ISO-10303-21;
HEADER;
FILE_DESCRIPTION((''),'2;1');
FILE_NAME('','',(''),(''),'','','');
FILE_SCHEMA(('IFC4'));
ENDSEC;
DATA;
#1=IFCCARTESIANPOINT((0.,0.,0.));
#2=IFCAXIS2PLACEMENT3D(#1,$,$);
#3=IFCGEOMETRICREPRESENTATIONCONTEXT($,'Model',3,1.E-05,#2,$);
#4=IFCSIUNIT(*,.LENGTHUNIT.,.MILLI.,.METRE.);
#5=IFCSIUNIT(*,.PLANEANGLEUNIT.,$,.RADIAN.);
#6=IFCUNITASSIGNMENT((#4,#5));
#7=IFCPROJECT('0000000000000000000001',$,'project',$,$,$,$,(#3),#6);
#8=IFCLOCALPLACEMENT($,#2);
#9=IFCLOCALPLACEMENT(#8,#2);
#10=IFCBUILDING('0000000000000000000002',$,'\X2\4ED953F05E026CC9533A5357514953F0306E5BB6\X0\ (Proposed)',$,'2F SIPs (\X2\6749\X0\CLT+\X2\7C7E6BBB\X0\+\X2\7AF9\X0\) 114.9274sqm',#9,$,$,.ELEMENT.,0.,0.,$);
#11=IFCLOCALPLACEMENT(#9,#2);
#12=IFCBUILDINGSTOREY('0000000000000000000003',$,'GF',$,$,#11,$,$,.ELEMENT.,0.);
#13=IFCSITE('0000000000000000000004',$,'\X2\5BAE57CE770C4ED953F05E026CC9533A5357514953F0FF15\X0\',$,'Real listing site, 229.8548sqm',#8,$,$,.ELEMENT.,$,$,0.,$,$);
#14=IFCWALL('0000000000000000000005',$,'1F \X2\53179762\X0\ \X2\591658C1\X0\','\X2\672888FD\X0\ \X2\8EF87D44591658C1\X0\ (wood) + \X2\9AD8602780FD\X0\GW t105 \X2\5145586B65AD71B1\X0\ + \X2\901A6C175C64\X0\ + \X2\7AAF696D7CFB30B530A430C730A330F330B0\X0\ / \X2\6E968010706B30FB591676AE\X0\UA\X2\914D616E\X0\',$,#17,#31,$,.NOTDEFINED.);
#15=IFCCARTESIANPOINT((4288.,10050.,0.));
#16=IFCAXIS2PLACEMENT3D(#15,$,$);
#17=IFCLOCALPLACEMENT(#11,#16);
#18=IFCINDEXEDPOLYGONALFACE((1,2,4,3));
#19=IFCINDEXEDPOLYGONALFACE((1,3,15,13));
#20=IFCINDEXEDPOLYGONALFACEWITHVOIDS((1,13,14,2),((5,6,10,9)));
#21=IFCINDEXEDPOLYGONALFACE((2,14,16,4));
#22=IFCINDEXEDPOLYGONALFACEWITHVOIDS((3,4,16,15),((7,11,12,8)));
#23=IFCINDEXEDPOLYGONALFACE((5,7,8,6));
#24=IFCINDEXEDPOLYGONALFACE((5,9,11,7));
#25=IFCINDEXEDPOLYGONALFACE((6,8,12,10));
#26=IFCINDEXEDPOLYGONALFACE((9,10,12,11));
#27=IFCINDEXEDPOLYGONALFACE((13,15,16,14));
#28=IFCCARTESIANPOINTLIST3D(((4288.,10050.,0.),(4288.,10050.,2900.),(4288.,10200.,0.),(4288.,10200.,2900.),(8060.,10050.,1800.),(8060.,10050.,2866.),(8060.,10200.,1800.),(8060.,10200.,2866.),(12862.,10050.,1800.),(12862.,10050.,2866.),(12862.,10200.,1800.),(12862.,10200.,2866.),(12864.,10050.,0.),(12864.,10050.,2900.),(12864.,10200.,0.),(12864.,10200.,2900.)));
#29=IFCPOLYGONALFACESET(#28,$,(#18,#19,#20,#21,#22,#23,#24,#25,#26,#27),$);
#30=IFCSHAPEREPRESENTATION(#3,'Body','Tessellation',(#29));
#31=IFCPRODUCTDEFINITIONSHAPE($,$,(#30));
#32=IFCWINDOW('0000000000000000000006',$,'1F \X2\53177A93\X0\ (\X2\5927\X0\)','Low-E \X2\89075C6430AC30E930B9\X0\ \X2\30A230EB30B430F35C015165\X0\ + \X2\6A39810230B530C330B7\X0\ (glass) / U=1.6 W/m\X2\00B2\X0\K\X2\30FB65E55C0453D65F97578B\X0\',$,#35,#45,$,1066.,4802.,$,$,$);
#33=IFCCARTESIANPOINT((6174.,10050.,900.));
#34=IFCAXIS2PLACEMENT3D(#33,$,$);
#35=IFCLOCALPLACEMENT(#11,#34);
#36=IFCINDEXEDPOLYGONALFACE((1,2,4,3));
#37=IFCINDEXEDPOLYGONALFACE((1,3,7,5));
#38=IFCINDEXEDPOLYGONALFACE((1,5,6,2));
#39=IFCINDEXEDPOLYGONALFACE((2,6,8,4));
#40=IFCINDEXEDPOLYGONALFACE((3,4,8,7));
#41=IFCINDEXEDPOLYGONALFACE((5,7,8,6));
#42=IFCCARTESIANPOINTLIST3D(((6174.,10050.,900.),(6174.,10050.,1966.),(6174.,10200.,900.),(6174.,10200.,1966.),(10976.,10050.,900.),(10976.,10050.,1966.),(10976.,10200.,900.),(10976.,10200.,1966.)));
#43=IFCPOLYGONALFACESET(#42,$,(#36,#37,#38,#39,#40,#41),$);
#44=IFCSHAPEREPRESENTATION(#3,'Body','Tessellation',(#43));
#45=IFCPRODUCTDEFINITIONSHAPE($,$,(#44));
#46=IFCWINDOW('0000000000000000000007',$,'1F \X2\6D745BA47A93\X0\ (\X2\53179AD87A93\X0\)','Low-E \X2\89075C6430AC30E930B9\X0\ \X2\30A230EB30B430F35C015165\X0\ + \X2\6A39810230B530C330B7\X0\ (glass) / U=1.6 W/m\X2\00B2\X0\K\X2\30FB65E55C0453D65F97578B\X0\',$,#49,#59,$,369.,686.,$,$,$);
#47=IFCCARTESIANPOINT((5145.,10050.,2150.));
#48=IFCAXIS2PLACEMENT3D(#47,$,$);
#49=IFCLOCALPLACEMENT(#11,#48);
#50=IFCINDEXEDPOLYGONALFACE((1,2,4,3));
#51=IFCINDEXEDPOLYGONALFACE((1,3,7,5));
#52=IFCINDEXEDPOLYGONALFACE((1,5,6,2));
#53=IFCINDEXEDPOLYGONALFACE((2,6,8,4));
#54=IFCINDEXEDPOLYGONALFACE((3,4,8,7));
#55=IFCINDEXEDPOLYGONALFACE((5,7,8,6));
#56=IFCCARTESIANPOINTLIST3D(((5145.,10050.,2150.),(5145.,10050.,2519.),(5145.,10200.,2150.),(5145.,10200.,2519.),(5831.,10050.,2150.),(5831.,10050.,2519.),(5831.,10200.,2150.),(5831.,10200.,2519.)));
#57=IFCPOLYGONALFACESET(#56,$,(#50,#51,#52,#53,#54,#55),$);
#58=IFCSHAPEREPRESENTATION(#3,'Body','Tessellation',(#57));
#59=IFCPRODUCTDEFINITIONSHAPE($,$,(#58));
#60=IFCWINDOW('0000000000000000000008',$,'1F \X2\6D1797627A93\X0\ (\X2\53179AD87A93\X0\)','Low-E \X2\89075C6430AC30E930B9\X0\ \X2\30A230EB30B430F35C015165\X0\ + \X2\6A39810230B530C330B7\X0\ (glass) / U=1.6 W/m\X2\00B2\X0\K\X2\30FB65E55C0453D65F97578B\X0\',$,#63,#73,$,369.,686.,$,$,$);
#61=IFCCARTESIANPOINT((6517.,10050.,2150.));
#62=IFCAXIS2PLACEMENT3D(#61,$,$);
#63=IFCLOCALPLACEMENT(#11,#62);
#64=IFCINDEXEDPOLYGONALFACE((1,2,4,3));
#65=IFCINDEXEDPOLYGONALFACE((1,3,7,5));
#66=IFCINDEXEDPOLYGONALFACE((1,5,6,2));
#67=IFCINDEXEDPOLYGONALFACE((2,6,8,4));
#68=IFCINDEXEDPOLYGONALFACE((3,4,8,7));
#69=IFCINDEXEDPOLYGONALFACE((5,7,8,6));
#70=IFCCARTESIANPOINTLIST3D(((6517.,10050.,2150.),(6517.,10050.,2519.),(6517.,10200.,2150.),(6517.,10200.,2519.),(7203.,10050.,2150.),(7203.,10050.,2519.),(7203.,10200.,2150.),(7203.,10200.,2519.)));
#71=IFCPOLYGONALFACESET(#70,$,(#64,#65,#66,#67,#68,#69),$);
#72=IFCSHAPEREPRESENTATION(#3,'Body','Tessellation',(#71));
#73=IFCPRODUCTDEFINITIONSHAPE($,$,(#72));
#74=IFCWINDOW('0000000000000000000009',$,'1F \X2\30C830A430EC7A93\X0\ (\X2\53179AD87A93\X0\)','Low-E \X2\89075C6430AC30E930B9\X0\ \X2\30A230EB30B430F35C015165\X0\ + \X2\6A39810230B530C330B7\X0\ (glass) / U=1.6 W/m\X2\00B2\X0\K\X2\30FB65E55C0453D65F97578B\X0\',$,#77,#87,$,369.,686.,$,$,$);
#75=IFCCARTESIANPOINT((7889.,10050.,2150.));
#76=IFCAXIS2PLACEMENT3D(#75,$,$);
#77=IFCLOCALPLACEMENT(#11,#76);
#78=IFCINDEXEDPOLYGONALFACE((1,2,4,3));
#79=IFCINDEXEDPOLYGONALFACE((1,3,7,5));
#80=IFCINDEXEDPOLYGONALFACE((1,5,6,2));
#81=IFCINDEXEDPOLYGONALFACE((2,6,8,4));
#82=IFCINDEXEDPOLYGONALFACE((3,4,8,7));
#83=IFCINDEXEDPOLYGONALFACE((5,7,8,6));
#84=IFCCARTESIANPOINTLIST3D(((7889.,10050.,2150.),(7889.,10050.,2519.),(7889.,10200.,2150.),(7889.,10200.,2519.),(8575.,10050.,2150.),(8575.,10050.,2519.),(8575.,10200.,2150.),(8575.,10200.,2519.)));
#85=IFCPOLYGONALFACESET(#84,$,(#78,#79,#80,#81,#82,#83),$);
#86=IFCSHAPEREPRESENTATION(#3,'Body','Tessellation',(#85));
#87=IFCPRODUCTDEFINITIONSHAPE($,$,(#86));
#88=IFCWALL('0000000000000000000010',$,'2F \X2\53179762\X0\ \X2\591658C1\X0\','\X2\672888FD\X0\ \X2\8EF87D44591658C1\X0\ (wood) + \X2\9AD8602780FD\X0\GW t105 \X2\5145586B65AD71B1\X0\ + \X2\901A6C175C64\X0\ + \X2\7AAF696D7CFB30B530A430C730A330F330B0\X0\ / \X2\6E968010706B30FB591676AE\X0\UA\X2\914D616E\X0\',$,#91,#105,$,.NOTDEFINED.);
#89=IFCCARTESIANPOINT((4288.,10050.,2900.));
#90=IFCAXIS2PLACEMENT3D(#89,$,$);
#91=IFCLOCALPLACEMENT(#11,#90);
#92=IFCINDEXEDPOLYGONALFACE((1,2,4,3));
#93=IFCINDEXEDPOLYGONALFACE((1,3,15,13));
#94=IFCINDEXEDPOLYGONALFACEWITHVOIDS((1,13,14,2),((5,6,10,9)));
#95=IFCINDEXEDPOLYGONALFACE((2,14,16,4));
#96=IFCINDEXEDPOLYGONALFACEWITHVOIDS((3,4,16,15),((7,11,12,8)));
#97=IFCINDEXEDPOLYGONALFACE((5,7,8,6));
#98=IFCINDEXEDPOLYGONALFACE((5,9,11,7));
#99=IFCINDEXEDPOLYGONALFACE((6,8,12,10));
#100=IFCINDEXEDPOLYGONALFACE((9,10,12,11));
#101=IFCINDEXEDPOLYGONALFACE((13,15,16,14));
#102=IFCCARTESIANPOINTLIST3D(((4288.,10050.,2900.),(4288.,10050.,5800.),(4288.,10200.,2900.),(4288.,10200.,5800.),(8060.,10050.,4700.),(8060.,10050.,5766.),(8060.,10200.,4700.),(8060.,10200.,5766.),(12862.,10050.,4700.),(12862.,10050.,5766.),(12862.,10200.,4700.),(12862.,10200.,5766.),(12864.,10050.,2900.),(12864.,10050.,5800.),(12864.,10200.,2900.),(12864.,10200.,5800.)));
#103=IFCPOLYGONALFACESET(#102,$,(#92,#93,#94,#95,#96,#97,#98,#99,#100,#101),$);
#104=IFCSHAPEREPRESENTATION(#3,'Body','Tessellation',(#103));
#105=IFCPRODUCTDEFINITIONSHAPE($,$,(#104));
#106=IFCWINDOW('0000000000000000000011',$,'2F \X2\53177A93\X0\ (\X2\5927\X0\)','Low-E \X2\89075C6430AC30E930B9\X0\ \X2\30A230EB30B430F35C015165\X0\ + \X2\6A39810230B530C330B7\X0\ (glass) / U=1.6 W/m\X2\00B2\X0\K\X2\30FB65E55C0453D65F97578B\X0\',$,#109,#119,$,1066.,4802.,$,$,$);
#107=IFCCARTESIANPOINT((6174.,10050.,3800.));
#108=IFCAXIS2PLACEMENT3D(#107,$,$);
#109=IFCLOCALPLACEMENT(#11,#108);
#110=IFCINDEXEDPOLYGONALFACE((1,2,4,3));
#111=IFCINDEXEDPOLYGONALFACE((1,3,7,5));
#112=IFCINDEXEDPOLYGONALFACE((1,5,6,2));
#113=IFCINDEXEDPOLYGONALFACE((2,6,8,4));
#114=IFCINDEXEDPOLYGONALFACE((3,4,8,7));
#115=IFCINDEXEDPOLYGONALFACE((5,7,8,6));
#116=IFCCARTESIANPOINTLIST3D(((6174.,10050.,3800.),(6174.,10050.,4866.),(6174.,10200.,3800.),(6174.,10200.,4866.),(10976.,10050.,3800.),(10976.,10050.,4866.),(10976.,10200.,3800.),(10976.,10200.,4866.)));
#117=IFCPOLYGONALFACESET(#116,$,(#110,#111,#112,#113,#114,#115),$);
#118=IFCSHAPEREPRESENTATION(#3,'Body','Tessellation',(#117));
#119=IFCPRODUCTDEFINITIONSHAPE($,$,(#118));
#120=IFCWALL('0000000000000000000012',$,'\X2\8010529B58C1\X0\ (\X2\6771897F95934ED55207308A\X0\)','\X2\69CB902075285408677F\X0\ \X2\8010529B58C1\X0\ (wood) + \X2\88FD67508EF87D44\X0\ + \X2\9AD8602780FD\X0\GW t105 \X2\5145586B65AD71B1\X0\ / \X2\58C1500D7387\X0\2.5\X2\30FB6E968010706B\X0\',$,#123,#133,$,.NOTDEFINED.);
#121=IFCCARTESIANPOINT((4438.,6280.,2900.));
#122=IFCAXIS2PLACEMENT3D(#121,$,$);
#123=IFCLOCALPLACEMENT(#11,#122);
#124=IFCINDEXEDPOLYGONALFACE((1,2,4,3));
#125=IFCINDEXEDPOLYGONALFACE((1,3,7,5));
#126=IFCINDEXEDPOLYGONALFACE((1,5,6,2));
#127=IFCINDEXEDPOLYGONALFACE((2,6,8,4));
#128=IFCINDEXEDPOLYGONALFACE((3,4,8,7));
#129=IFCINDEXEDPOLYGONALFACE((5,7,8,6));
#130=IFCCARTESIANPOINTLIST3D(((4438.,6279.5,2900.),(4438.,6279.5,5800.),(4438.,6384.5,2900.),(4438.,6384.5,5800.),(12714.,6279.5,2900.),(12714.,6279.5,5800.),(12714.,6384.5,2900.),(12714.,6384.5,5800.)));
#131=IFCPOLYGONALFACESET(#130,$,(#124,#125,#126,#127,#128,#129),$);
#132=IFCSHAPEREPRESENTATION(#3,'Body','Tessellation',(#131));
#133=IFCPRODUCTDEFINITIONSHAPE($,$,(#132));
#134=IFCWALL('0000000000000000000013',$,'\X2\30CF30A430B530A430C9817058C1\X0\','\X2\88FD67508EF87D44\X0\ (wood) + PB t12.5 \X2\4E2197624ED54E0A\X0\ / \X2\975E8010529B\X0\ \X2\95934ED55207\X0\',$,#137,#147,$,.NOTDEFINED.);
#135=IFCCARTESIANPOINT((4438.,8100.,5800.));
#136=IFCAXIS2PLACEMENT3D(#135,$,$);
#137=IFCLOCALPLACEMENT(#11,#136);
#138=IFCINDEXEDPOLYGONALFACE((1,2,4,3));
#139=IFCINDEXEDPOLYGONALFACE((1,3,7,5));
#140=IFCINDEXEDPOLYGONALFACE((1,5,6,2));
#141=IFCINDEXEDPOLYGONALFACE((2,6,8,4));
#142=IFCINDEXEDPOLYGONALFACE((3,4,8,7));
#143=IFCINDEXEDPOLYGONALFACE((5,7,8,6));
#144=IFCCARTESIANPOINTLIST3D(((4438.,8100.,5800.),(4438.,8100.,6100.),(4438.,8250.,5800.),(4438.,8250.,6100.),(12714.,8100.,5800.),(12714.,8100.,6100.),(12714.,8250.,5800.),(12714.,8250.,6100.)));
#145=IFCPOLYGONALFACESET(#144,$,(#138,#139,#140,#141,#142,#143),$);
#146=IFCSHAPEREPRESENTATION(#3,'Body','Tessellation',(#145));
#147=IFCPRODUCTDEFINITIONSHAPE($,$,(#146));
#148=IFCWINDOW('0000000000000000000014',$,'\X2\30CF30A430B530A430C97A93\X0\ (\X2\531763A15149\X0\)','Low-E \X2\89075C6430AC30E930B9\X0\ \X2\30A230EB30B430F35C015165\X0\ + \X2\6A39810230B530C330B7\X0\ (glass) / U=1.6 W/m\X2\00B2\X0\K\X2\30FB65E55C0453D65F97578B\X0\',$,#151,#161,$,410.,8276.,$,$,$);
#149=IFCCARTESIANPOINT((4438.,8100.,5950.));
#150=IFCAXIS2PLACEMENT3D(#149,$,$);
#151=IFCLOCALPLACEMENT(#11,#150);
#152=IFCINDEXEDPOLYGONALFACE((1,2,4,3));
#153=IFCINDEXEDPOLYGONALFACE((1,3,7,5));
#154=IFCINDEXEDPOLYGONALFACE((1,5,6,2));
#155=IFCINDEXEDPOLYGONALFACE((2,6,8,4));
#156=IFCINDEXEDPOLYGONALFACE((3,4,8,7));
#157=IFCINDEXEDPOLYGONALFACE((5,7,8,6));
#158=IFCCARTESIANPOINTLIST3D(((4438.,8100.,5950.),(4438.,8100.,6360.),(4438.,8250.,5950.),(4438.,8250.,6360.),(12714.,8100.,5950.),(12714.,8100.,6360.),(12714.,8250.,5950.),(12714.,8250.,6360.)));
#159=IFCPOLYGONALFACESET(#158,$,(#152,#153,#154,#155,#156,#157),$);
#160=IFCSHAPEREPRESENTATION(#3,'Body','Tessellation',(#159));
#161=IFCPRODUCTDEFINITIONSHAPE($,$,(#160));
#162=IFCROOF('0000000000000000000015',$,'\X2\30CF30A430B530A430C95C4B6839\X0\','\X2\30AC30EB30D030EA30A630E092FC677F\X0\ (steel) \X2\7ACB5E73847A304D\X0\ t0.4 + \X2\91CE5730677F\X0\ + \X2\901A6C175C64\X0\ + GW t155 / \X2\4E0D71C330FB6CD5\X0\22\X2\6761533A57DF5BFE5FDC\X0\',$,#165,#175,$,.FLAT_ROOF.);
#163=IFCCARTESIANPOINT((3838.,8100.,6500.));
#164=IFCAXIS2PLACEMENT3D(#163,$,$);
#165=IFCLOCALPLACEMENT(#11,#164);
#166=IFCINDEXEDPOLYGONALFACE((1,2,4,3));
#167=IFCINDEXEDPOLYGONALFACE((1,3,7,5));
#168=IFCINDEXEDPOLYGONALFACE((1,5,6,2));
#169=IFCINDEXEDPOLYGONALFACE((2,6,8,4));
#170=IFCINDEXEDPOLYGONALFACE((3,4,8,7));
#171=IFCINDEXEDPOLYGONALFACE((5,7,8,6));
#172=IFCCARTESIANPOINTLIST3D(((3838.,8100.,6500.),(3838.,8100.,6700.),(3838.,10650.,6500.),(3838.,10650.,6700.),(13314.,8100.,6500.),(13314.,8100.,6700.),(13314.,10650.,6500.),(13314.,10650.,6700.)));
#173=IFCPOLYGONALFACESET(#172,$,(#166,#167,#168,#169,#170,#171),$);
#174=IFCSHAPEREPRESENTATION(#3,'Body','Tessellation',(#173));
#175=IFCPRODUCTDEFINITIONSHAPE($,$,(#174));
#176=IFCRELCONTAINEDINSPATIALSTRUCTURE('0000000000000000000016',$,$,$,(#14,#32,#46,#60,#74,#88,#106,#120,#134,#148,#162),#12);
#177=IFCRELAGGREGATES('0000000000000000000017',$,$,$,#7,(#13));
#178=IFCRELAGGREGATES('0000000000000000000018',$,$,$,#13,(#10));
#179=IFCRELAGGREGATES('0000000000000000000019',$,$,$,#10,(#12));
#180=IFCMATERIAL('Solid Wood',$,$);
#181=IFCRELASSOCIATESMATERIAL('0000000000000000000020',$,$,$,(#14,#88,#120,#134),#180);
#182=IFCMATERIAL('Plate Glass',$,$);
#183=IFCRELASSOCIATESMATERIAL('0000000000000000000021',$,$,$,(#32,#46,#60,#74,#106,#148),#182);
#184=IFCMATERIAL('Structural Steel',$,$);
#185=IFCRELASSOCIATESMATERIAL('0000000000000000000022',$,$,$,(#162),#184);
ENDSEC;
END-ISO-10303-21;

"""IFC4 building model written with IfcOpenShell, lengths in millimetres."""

from ifc_helpers import new_model, si_unit, frame, frame_2d, origin, place, context, project, spatial, rectangle, extrude, material, element, fill, save


model = new_model("IFC4")

# Units and contexts
model_context = context("Model", 3, precision=1e-05, world=origin())
ifc_project = project(units=[si_unit("LENGTHUNIT", "METRE", prefix="MILLI"), si_unit("PLANEANGLEUNIT", "RADIAN")], contexts=[model_context])

# Site, building, storey
site_placement = place(None, origin())
site = spatial("IfcSite", under=ifc_project, at=site_placement, Name="宮城県仙台市泉区南光台５", ObjectType="Real listing site, 229.8548sqm", CompositionType="ELEMENT", RefElevation=0.0)
building_placement = place(site_placement, origin())
building = spatial("IfcBuilding", under=site, at=building_placement, Name="仙台市泉区南光台の家 (Proposed)", ObjectType="2F SIPs (杉CLT+籾殻+竹) 114.9274sqm", CompositionType="ELEMENT", ElevationOfRefHeight=0.0, ElevationOfTerrain=0.0)
storey_placement = place(building_placement, origin())
storey = spatial("IfcBuildingStorey", under=building, at=storey_placement, Name="GF", CompositionType="ELEMENT", Elevation=0.0)

# Wall, openings, windows
ifc_material_1 = material(Name="Solid Wood")
wall_1_placement = place(storey_placement, frame((4288.0, 10050.0, 0.0)))
wall_1 = element("IfcWall", 1, at=wall_1_placement, inside=storey, material=ifc_material_1, Name="1F 北面 外壁", Description="木製 軸組外壁 (wood) + 高性能GW t105 充填断熱 + 通気層 + 窯業系サイディング / 準耐火・外皮UA配慮", PredefinedType="NOTDEFINED", context=model_context, shape_type="SweptSolid", body=[
    extrude(rectangle(XDim=8576.0, YDim=150.0, at=frame_2d((4288.0, 75.0))), frame((4288.0, 10050.0, 0.0)), (0.0, 0.0, 1.0), 2900.0),
])
opening_1_placement = place(storey_placement, frame((6174.0, 10050.0, 900.0)))
opening_1 = element("IfcOpeningElement", 2, at=opening_1_placement, cuts=wall_1, PredefinedType="NOTDEFINED", context=model_context, shape_type="SweptSolid", body=[
    extrude(rectangle(XDim=4802.0, YDim=150.0, at=frame_2d((2401.0, 75.0))), frame((6174.0, 10050.0, 900.0)), (0.0, 0.0, 1.0), 1066.0),
])
opening_2_placement = place(storey_placement, frame((5145.0, 10050.0, 2150.0)))
opening_2 = element("IfcOpeningElement", 3, at=opening_2_placement, cuts=wall_1, PredefinedType="NOTDEFINED", context=model_context, shape_type="SweptSolid", body=[
    extrude(rectangle(XDim=686.0, YDim=150.0, at=frame_2d((343.0, 75.0))), frame((5145.0, 10050.0, 2150.0)), (0.0, 0.0, 1.0), 369.0),
])
opening_3_placement = place(storey_placement, frame((6517.0, 10050.0, 2150.0)))
opening_3 = element("IfcOpeningElement", 4, at=opening_3_placement, cuts=wall_1, PredefinedType="NOTDEFINED", context=model_context, shape_type="SweptSolid", body=[
    extrude(rectangle(XDim=686.0, YDim=150.0, at=frame_2d((343.0, 75.0))), frame((6517.0, 10050.0, 2150.0)), (0.0, 0.0, 1.0), 369.0),
])
opening_4_placement = place(storey_placement, frame((7889.0, 10050.0, 2150.0)))
opening_4 = element("IfcOpeningElement", 5, at=opening_4_placement, cuts=wall_1, PredefinedType="NOTDEFINED", context=model_context, shape_type="SweptSolid", body=[
    extrude(rectangle(XDim=686.0, YDim=150.0, at=frame_2d((343.0, 75.0))), frame((7889.0, 10050.0, 2150.0)), (0.0, 0.0, 1.0), 369.0),
])
ifc_material_2 = material(Name="Plate Glass")
window_1_placement = place(storey_placement, frame((6174.0, 10050.0, 900.0)))
window_1 = element("IfcWindow", 6, at=window_1_placement, inside=storey, material=ifc_material_2, Name="1F 北窓 (大)", Description="Low-E 複層ガラス アルゴン封入 + 樹脂サッシ (glass) / U=1.6 W/m²K・日射取得型", OverallHeight=1066.0, OverallWidth=4802.0, context=model_context, shape_type="SweptSolid", body=[
    extrude(rectangle(XDim=4802.0, YDim=150.0, at=frame_2d((2401.0, 75.0))), frame((6174.0, 10050.0, 900.0)), (0.0, 0.0, 1.0), 1066.0),
])
fill(opening_1, window_1)
window_2_placement = place(storey_placement, frame((5145.0, 10050.0, 2150.0)))
window_2 = element("IfcWindow", 7, at=window_2_placement, inside=storey, material=ifc_material_2, Name="1F 浴室窓 (北高窓)", Description="Low-E 複層ガラス アルゴン封入 + 樹脂サッシ (glass) / U=1.6 W/m²K・日射取得型", OverallHeight=369.0, OverallWidth=686.0, context=model_context, shape_type="SweptSolid", body=[
    extrude(rectangle(XDim=686.0, YDim=150.0, at=frame_2d((343.0, 75.0))), frame((5145.0, 10050.0, 2150.0)), (0.0, 0.0, 1.0), 369.0),
])
fill(opening_2, window_2)
window_3_placement = place(storey_placement, frame((6517.0, 10050.0, 2150.0)))
window_3 = element("IfcWindow", 8, at=window_3_placement, inside=storey, material=ifc_material_2, Name="1F 洗面窓 (北高窓)", Description="Low-E 複層ガラス アルゴン封入 + 樹脂サッシ (glass) / U=1.6 W/m²K・日射取得型", OverallHeight=369.0, OverallWidth=686.0, context=model_context, shape_type="SweptSolid", body=[
    extrude(rectangle(XDim=686.0, YDim=150.0, at=frame_2d((343.0, 75.0))), frame((6517.0, 10050.0, 2150.0)), (0.0, 0.0, 1.0), 369.0),
])
fill(opening_3, window_3)
window_4_placement = place(storey_placement, frame((7889.0, 10050.0, 2150.0)))
window_4 = element("IfcWindow", 9, at=window_4_placement, inside=storey, material=ifc_material_2, Name="1F トイレ窓 (北高窓)", Description="Low-E 複層ガラス アルゴン封入 + 樹脂サッシ (glass) / U=1.6 W/m²K・日射取得型", OverallHeight=369.0, OverallWidth=686.0, context=model_context, shape_type="SweptSolid", body=[
    extrude(rectangle(XDim=686.0, YDim=150.0, at=frame_2d((343.0, 75.0))), frame((7889.0, 10050.0, 2150.0)), (0.0, 0.0, 1.0), 369.0),
])
fill(opening_4, window_4)

# Wall, opening, window
wall_2_placement = place(storey_placement, frame((4288.0, 10050.0, 2900.0)))
wall_2 = element("IfcWall", 10, at=wall_2_placement, inside=storey, material=ifc_material_1, Name="2F 北面 外壁", Description="木製 軸組外壁 (wood) + 高性能GW t105 充填断熱 + 通気層 + 窯業系サイディング / 準耐火・外皮UA配慮", PredefinedType="NOTDEFINED", context=model_context, shape_type="SweptSolid", body=[
    extrude(rectangle(XDim=8576.0, YDim=150.0, at=frame_2d((4288.0, 75.0))), frame((4288.0, 10050.0, 2900.0)), (0.0, 0.0, 1.0), 2900.0),
])
opening_5_placement = place(storey_placement, frame((6174.0, 10050.0, 3800.0)))
opening_5 = element("IfcOpeningElement", 11, at=opening_5_placement, cuts=wall_2, PredefinedType="NOTDEFINED", context=model_context, shape_type="SweptSolid", body=[
    extrude(rectangle(XDim=4802.0, YDim=150.0, at=frame_2d((2401.0, 75.0))), frame((6174.0, 10050.0, 3800.0)), (0.0, 0.0, 1.0), 1066.0),
])
window_5_placement = place(storey_placement, frame((6174.0, 10050.0, 3800.0)))
window_5 = element("IfcWindow", 12, at=window_5_placement, inside=storey, material=ifc_material_2, Name="2F 北窓 (大)", Description="Low-E 複層ガラス アルゴン封入 + 樹脂サッシ (glass) / U=1.6 W/m²K・日射取得型", OverallHeight=1066.0, OverallWidth=4802.0, context=model_context, shape_type="SweptSolid", body=[
    extrude(rectangle(XDim=4802.0, YDim=150.0, at=frame_2d((2401.0, 75.0))), frame((6174.0, 10050.0, 3800.0)), (0.0, 0.0, 1.0), 1066.0),
])
fill(opening_5, window_5)

# Wall
wall_3_placement = place(storey_placement, frame((4438.0, 6280.0, 2900.0)))
element("IfcWall", 13, at=wall_3_placement, inside=storey, material=ifc_material_1, Name="耐力壁 (東西間仕切り)", Description="構造用合板 耐力壁 (wood) + 製材軸組 + 高性能GW t105 充填断熱 / 壁倍率2.5・準耐火", PredefinedType="NOTDEFINED", context=model_context, shape_type="SweptSolid", body=[
    extrude(rectangle(XDim=8276.0, YDim=105.0, at=frame_2d((4138.0, 52.0))), frame((4438.0, 6280.0, 2900.0)), (0.0, 0.0, 1.0), 2900.0),
])

# Wall, opening, window
wall_4_placement = place(storey_placement, frame((4438.0, 8100.0, 5800.0)))
wall_4 = element("IfcWall", 14, at=wall_4_placement, inside=storey, material=ifc_material_1, Name="ハイサイド腰壁", Description="製材軸組 (wood) + PB t12.5 両面仕上 / 非耐力 間仕切", PredefinedType="NOTDEFINED", context=model_context, shape_type="SweptSolid", body=[
    extrude(rectangle(XDim=8276.0, YDim=150.0, at=frame_2d((4138.0, 75.0))), frame((4438.0, 8100.0, 5800.0)), (0.0, 0.0, 1.0), 700.0),
])
opening_6_placement = place(storey_placement, frame((4438.0, 8100.0, 5950.0)))
opening_6 = element("IfcOpeningElement", 15, at=opening_6_placement, cuts=wall_4, PredefinedType="NOTDEFINED", context=model_context, shape_type="SweptSolid", body=[
    extrude(rectangle(XDim=8276.0, YDim=150.0, at=frame_2d((4138.0, 75.0))), frame((4438.0, 8100.0, 5950.0)), (0.0, 0.0, 1.0), 410.0),
])
window_6_placement = place(storey_placement, frame((4438.0, 8100.0, 5950.0)))
window_6 = element("IfcWindow", 16, at=window_6_placement, inside=storey, material=ifc_material_2, Name="ハイサイド窓 (北採光)", Description="Low-E 複層ガラス アルゴン封入 + 樹脂サッシ (glass) / U=1.6 W/m²K・日射取得型", OverallHeight=410.0, OverallWidth=8276.0, context=model_context, shape_type="SweptSolid", body=[
    extrude(rectangle(XDim=8276.0, YDim=150.0, at=frame_2d((4138.0, 75.0))), frame((4438.0, 8100.0, 5950.0)), (0.0, 0.0, 1.0), 410.0),
])
fill(opening_6, window_6)

# Roof
ifc_material_3 = material(Name="Structural Steel")
roof_placement = place(storey_placement, frame((3838.0, 8100.0, 6500.0)))
element("IfcRoof", 17, at=roof_placement, inside=storey, material=ifc_material_3, Name="ハイサイド屋根", Description="ガルバリウム鋼板 (steel) 立平葺き t0.4 + 野地板 + 通気層 + GW t155 / 不燃・法22条区域対応", PredefinedType="FLAT_ROOF", context=model_context, shape_type="SweptSolid", body=[
    extrude(rectangle(XDim=9476.0, YDim=2550.0, at=frame_2d((4738.0, 1275.0))), frame((3838.0, 8100.0, 6500.0)), (0.0, 0.0, 1.0), 200.0),
])

save(model, "model.ifc")
